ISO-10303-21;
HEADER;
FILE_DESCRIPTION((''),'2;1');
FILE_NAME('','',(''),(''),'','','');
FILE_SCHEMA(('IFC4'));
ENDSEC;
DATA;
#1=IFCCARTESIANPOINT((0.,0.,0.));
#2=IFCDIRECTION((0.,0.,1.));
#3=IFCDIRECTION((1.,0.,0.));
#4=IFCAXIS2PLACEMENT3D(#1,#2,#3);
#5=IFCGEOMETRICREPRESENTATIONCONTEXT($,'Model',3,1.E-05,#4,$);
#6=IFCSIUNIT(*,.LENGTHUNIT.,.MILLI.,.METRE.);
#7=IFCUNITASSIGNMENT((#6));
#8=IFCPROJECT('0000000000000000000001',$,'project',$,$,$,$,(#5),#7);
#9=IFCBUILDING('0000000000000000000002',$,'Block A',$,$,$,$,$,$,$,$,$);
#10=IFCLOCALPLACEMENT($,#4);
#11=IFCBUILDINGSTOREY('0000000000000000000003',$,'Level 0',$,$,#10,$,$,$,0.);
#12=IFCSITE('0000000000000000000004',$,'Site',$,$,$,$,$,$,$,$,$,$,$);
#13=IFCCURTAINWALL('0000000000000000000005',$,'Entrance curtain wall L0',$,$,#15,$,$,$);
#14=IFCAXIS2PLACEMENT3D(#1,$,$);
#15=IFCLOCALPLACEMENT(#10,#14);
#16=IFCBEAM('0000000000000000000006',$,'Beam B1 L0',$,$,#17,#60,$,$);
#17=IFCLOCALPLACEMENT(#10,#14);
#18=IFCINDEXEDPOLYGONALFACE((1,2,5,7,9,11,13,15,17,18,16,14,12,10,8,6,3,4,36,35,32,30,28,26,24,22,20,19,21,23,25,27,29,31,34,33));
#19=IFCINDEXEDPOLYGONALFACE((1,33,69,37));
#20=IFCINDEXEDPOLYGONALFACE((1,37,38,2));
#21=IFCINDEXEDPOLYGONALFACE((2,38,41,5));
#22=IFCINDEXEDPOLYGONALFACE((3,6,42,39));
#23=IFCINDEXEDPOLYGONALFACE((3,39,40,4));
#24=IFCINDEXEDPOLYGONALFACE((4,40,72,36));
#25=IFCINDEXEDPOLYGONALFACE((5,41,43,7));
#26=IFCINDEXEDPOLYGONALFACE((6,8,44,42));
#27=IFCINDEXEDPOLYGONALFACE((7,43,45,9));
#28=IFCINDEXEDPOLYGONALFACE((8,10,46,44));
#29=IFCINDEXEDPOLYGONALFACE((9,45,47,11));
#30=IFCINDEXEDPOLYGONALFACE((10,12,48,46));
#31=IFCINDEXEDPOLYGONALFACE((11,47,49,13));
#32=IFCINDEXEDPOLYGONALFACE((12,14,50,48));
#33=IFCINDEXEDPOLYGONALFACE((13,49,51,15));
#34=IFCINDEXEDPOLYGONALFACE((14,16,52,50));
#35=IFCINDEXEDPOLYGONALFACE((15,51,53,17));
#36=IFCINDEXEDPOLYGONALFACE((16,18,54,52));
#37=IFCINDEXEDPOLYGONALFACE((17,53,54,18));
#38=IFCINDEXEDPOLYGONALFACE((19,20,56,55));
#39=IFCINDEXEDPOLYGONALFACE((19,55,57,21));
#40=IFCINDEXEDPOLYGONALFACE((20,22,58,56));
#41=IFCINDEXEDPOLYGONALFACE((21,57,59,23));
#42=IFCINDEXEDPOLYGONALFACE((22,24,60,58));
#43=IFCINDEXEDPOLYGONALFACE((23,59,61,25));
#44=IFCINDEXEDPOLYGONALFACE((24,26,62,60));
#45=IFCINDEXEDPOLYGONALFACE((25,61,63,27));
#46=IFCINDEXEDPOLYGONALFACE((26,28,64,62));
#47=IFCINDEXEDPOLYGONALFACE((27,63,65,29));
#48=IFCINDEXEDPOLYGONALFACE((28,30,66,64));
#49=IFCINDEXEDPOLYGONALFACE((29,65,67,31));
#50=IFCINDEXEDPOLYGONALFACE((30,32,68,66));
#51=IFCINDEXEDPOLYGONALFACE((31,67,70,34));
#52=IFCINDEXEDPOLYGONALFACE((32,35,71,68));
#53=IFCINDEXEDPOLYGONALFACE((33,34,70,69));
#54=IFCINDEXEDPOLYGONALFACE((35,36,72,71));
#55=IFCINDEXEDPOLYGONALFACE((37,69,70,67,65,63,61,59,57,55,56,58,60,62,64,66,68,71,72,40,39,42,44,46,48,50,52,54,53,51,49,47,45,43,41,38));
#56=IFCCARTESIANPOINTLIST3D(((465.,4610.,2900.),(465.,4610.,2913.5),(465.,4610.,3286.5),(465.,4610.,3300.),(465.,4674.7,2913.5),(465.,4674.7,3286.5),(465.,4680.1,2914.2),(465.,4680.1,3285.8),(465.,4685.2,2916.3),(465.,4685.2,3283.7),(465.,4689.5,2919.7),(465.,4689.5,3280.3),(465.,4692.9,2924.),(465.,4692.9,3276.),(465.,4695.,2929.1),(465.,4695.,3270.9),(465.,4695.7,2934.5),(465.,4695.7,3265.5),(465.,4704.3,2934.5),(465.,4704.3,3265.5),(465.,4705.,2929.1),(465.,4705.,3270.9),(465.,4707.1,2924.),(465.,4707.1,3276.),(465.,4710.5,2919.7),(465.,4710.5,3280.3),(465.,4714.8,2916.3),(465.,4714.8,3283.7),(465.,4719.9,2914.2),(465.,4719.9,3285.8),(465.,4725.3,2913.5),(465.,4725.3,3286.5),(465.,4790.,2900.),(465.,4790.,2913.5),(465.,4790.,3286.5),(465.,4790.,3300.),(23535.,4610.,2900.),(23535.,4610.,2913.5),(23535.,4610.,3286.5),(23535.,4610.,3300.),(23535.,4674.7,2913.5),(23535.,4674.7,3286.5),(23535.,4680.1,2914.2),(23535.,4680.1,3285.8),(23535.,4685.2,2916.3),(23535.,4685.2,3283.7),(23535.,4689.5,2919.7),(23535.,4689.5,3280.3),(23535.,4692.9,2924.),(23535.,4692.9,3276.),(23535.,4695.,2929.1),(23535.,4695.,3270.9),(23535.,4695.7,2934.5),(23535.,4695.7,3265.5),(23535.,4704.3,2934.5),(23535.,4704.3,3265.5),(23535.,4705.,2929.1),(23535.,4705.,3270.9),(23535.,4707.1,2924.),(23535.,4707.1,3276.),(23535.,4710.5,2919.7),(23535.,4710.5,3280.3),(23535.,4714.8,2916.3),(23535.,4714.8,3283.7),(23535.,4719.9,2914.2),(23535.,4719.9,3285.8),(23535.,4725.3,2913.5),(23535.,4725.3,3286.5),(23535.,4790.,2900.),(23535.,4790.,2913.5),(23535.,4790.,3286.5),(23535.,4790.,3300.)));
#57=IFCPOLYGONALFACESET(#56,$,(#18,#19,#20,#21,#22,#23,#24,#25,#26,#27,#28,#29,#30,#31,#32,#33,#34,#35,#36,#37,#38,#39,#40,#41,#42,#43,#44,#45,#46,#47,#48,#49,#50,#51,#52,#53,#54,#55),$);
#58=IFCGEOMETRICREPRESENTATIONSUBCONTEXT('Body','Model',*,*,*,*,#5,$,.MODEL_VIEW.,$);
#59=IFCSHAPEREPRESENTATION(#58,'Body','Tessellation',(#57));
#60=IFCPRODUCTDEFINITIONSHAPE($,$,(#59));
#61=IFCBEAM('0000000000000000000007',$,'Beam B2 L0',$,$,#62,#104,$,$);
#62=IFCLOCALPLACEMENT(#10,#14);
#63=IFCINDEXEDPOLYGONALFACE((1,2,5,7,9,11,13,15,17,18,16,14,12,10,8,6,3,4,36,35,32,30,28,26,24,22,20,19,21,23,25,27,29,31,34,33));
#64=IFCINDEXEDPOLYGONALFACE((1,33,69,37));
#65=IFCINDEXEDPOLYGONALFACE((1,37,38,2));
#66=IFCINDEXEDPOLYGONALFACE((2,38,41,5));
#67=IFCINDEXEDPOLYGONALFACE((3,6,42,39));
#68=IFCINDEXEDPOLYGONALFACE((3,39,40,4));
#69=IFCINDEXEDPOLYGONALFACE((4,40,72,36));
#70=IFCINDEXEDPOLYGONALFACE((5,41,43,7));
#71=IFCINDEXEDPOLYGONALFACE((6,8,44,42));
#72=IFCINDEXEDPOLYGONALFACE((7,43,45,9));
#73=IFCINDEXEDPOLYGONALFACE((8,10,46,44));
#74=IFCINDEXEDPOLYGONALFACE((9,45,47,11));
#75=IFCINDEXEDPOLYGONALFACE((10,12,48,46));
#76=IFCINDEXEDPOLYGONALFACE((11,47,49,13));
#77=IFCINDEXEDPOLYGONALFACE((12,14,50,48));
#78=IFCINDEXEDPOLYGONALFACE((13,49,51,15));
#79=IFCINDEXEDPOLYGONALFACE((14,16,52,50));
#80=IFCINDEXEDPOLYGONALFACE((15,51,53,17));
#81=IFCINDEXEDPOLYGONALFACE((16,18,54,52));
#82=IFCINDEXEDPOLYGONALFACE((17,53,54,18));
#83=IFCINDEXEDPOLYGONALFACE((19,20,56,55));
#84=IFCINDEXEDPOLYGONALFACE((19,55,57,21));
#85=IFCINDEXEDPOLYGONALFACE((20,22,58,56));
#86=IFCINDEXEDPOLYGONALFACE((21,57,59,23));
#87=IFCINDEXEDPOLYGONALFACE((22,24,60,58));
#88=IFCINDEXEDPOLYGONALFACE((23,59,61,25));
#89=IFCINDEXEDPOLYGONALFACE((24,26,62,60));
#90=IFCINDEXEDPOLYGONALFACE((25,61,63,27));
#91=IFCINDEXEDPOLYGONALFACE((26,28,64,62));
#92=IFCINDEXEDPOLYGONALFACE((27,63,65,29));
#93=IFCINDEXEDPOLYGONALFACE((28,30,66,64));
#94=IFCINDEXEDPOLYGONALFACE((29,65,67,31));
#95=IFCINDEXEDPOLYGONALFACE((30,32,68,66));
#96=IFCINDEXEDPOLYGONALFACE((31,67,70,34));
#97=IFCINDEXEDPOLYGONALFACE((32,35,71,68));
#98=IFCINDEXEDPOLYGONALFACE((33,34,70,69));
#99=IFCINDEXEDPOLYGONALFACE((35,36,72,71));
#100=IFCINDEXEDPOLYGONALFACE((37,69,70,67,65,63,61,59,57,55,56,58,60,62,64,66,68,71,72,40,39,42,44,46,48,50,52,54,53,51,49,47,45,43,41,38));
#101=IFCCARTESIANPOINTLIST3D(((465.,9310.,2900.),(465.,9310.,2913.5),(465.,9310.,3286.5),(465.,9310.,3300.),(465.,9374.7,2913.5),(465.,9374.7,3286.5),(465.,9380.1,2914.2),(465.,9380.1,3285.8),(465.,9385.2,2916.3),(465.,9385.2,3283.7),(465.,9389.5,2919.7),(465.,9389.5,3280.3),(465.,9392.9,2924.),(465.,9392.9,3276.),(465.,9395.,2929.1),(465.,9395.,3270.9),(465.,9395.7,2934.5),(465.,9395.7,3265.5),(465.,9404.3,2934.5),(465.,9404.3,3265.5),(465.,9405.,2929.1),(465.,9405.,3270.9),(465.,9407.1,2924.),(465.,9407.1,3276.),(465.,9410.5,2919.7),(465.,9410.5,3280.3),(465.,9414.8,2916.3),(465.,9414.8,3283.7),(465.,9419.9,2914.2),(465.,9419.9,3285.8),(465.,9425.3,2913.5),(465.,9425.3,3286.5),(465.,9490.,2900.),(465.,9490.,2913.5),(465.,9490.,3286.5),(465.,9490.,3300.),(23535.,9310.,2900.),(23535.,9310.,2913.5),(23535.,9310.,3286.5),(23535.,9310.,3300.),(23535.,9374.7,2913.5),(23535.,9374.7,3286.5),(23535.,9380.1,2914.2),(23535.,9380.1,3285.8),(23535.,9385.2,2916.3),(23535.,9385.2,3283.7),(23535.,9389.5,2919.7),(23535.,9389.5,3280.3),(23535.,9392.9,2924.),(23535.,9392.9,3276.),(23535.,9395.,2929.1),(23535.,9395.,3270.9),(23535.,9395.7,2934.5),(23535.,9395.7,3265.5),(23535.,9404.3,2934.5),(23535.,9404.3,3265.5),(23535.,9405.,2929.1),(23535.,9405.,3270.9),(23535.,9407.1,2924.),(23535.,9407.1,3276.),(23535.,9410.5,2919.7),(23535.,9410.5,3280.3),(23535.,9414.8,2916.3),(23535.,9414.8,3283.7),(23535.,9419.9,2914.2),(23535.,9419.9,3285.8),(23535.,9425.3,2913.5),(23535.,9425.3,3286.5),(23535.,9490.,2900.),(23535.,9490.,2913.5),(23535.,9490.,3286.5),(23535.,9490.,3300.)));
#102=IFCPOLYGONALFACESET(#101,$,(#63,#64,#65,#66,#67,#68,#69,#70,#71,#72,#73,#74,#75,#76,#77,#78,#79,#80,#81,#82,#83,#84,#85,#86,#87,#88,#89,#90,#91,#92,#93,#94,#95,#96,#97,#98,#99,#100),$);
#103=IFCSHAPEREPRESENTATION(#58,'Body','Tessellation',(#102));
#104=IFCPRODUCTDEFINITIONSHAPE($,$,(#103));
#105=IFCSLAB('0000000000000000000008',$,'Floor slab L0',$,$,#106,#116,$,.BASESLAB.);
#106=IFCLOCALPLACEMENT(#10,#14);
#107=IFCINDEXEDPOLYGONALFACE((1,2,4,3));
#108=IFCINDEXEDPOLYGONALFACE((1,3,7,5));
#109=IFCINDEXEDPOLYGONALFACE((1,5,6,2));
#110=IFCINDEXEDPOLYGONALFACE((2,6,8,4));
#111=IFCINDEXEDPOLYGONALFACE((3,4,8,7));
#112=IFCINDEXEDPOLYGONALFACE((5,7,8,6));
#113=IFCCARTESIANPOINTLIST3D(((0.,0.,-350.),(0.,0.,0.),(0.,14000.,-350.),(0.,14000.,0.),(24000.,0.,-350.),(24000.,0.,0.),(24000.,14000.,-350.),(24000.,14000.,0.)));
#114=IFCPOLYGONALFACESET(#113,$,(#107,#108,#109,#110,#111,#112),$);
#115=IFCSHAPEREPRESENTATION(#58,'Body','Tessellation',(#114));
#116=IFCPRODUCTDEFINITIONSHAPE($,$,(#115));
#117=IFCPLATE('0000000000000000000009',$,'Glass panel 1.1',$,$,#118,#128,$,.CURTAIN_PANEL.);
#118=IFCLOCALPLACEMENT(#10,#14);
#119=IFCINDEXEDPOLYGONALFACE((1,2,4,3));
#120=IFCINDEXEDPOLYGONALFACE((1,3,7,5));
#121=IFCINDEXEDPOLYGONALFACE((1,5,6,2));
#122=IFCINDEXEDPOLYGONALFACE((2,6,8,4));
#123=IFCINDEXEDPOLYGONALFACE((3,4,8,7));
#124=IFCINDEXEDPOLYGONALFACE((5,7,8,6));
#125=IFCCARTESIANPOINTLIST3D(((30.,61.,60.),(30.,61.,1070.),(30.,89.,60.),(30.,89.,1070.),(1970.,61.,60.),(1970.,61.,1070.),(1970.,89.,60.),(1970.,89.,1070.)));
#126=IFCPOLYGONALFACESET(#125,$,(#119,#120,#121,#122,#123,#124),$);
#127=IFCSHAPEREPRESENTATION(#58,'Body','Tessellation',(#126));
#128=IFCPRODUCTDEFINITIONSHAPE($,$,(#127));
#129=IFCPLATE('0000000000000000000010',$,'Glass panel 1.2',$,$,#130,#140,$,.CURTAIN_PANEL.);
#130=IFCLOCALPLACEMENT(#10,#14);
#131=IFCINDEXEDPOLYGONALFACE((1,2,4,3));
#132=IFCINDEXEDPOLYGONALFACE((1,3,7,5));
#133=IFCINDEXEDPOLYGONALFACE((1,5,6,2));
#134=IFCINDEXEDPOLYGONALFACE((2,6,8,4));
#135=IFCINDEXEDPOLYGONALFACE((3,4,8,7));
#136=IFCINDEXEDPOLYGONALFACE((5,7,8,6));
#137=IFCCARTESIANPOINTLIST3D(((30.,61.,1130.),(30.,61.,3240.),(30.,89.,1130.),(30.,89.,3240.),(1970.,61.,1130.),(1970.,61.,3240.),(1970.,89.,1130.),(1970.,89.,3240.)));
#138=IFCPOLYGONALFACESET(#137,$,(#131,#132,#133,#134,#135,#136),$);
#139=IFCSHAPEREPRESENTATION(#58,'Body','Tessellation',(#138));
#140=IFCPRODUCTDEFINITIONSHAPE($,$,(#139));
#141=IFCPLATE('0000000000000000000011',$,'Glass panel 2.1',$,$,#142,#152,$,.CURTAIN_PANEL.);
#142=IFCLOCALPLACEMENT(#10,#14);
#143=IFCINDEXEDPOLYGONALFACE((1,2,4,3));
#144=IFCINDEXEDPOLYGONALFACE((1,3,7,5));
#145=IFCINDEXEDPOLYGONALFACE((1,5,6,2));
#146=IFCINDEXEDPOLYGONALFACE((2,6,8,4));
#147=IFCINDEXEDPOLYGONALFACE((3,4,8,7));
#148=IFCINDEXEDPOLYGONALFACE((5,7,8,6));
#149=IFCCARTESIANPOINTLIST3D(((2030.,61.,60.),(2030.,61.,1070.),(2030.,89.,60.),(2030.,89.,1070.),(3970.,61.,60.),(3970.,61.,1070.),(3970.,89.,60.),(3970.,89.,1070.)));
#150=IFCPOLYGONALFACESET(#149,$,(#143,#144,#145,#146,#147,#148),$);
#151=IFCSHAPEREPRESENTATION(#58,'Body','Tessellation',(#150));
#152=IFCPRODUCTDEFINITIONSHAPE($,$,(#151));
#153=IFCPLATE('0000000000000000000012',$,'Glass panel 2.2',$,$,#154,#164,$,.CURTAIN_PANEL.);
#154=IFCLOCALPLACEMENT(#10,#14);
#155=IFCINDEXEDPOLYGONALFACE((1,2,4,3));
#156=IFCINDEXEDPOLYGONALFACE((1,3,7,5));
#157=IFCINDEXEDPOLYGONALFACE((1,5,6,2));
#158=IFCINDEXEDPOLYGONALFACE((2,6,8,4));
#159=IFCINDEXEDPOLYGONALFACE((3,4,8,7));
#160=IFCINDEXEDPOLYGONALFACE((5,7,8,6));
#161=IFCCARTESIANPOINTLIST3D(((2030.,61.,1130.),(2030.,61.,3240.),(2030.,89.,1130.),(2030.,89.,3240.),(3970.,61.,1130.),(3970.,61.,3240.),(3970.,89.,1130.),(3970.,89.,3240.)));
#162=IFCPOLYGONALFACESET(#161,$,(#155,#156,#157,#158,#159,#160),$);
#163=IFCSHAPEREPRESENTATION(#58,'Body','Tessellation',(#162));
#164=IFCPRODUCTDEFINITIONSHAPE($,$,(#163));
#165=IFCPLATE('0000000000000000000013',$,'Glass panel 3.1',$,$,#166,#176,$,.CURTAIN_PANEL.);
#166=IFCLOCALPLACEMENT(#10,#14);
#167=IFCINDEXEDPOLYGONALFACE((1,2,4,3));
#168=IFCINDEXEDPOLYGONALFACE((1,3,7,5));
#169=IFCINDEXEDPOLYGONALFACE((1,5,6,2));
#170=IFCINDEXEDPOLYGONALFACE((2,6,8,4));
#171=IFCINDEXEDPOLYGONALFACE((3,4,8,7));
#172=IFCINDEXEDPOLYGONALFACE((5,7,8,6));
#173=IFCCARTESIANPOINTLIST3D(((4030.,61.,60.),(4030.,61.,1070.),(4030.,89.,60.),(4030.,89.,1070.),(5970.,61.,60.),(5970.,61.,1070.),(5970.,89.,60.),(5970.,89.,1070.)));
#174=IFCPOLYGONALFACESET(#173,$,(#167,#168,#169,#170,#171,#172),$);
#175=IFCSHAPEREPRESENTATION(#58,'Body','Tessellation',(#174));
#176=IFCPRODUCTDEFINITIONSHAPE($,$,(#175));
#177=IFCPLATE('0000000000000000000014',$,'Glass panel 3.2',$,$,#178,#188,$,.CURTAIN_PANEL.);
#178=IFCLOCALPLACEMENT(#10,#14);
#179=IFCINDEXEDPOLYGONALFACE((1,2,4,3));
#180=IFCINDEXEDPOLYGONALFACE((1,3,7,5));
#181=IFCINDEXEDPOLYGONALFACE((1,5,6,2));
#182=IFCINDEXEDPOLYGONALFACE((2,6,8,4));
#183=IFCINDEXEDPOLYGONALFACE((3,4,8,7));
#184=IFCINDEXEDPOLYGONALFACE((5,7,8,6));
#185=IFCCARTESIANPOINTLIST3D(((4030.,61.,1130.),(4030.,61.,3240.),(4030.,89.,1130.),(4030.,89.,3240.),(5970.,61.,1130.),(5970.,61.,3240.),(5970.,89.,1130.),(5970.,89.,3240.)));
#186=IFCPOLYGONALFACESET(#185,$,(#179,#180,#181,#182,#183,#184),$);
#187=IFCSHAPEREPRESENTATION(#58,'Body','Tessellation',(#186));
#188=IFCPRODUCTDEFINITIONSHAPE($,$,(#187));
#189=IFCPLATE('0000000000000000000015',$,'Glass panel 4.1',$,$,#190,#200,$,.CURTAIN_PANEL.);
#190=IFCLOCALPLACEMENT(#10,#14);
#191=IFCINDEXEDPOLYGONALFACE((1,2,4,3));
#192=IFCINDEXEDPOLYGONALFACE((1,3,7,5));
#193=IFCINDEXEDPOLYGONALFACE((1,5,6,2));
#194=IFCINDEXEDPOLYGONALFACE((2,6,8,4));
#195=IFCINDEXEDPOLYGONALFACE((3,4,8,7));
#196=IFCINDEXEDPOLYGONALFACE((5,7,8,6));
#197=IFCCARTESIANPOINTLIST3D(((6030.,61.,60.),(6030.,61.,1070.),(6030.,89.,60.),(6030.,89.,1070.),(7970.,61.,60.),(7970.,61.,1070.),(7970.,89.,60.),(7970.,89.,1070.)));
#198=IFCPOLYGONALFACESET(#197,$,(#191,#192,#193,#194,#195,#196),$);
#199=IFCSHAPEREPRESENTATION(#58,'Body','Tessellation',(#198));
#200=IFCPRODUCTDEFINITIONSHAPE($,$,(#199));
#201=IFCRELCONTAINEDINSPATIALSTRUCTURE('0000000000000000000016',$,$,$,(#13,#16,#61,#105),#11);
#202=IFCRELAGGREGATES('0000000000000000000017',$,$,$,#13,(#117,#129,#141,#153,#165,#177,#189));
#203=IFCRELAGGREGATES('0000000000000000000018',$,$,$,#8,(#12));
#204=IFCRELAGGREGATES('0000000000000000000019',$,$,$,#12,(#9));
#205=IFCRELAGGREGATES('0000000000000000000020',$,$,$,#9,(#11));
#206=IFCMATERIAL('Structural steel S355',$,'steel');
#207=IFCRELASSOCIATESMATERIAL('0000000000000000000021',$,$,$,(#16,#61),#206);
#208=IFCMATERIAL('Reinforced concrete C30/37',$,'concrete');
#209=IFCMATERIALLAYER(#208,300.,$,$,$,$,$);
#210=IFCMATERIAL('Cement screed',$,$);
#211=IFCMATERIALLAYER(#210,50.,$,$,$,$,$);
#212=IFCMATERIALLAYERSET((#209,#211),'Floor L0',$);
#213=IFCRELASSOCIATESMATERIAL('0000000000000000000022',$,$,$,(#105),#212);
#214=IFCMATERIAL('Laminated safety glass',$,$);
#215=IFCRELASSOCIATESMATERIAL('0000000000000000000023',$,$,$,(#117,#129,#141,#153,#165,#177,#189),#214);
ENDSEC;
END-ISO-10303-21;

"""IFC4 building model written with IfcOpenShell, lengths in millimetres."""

from ifc_helpers import new_model, si_unit, frame, origin_with_axes, place, context, subcontext, project, spatial, indexed_curve, i_section, outline, extrude, material, layer, layer_set, layer_usage, material_profile, profile_set, element, aggregate, save


model = new_model("IFC4")

# Units and contexts
model_context = context("Model", 3, precision=1e-05, world=origin_with_axes())
body_context = subcontext(model_context, "Body", "Model", "MODEL_VIEW")
ifc_project = project(units=[si_unit("LENGTHUNIT", "METRE", prefix="MILLI")], contexts=[model_context])

# Site, building, storey
site = spatial("IfcSite", under=ifc_project, Name="Site")
building = spatial("IfcBuilding", under=site, Name="Block A")
storey_placement = place(None, origin_with_axes())
storey = spatial("IfcBuildingStorey", under=building, at=storey_placement, Name="Level 0", Elevation=0.0)

# Shared definitions
ifc_material_1 = material(Name="Structural steel S355", Category="steel")

# Curtain wall
curtain_wall_placement = place(storey_placement, origin_with_axes())
curtain_wall = element("IfcCurtainWall", 1, at=curtain_wall_placement, inside=storey, Name="Entrance curtain wall L0")

# Beams
ifc_material_profile_1 = material_profile(ifc_material_1, i_section(OverallWidth=180.0, OverallDepth=400.0, WebThickness=8.6, FlangeThickness=13.5, FilletRadius=21.0))
ifc_profile_set_1 = profile_set([ifc_material_profile_1], Name="IPE 400")
for number, where, z_axis, x_axis, name in (
    (2, (465.0, 4700.0, 3100.0), (1.0, 0.0, 0.0), (0.0, 1.0, 0.0), "Beam B1 L0"),
    (3, (465.0, 9400.0, 3100.0), (1.0, 0.0, 0.0), (0.0, 1.0, 0.0), "Beam B2 L0"),
):
    element("IfcBeam", number, at=place(storey_placement, frame(where, z_axis=z_axis, x_axis=x_axis)), inside=storey, material=ifc_profile_set_1, Name=name, context=body_context, shape_type="SweptSolid", body=[
        extrude(i_section(OverallWidth=180.0, OverallDepth=400.0, WebThickness=8.6, FlangeThickness=13.5, FilletRadius=21.0), origin_with_axes(), (0.0, 0.0, 1.0), 23070.0),
    ])

# Slab
ifc_material_2 = material(Name="Reinforced concrete C30/37", Category="concrete")
ifc_layer_1 = layer(ifc_material_2, 300.0)
ifc_material_3 = material(Name="Cement screed")
ifc_layer_2 = layer(ifc_material_3, 50.0)
ifc_layer_set_1 = layer_set([ifc_layer_1, ifc_layer_2], Name="Floor L0")
ifc_layer_usage_1 = layer_usage(ifc_layer_set_1, "AXIS3", "POSITIVE", 0.0)
slab_placement = place(storey_placement, frame((0.0, 0.0, -350.0), z_axis=(0.0, 0.0, 1.0), x_axis=(1.0, 0.0, 0.0)))
element("IfcSlab", 4, at=slab_placement, inside=storey, material=ifc_layer_usage_1, Name="Floor slab L0", PredefinedType="BASESLAB", context=body_context, shape_type="SweptSolid", body=[
    extrude(outline(indexed_curve([(0.0, 0.0), (24000.0, 0.0), (24000.0, 14000.0), (0.0, 14000.0), (0.0, 0.0)])), None, (0.0, 0.0, 1.0), 350.0),
])

# Plates
ifc_material_4 = material(Name="Laminated safety glass")
plate_1_placement = place(curtain_wall_placement, frame((30.0, 61.0, 60.0), z_axis=(0.0, 0.0, 1.0), x_axis=(1.0, 0.0, 0.0)))
plate_1 = element("IfcPlate", 5, at=plate_1_placement, material=ifc_material_4, Name="Glass panel 1.1", PredefinedType="CURTAIN_PANEL", context=body_context, shape_type="SweptSolid", body=[
    extrude(outline(indexed_curve([(0.0, 0.0), (0.0, 28.0), (1940.0, 28.0), (1940.0, 0.0), (0.0, 0.0)], self_intersect=False)), origin_with_axes(), (0.0, 0.0, 1.0), 1010.0),
])
plate_2_placement = place(curtain_wall_placement, frame((30.0, 61.0, 1130.0), z_axis=(0.0, 0.0, 1.0), x_axis=(1.0, 0.0, 0.0)))
plate_2 = element("IfcPlate", 6, at=plate_2_placement, material=ifc_material_4, Name="Glass panel 1.2", PredefinedType="CURTAIN_PANEL", context=body_context, shape_type="SweptSolid", body=[
    extrude(outline(indexed_curve([(0.0, 0.0), (0.0, 28.0), (1940.0, 28.0), (1940.0, 0.0), (0.0, 0.0)], self_intersect=False)), origin_with_axes(), (0.0, 0.0, 1.0), 2110.0),
])
plate_3_placement = place(curtain_wall_placement, frame((2030.0, 61.0, 60.0), z_axis=(0.0, 0.0, 1.0), x_axis=(1.0, 0.0, 0.0)))
plate_3 = element("IfcPlate", 7, at=plate_3_placement, material=ifc_material_4, Name="Glass panel 2.1", PredefinedType="CURTAIN_PANEL", context=body_context, shape_type="SweptSolid", body=[
    extrude(outline(indexed_curve([(0.0, 0.0), (0.0, 28.0), (1940.0, 28.0), (1940.0, 0.0), (0.0, 0.0)], self_intersect=False)), origin_with_axes(), (0.0, 0.0, 1.0), 1010.0),
])
plate_4_placement = place(curtain_wall_placement, frame((2030.0, 61.0, 1130.0), z_axis=(0.0, 0.0, 1.0), x_axis=(1.0, 0.0, 0.0)))
plate_4 = element("IfcPlate", 8, at=plate_4_placement, material=ifc_material_4, Name="Glass panel 2.2", PredefinedType="CURTAIN_PANEL", context=body_context, shape_type="SweptSolid", body=[
    extrude(outline(indexed_curve([(0.0, 0.0), (0.0, 28.0), (1940.0, 28.0), (1940.0, 0.0), (0.0, 0.0)], self_intersect=False)), origin_with_axes(), (0.0, 0.0, 1.0), 2110.0),
])
plate_5_placement = place(curtain_wall_placement, frame((4030.0, 61.0, 60.0), z_axis=(0.0, 0.0, 1.0), x_axis=(1.0, 0.0, 0.0)))
plate_5 = element("IfcPlate", 9, at=plate_5_placement, material=ifc_material_4, Name="Glass panel 3.1", PredefinedType="CURTAIN_PANEL", context=body_context, shape_type="SweptSolid", body=[
    extrude(outline(indexed_curve([(0.0, 0.0), (0.0, 28.0), (1940.0, 28.0), (1940.0, 0.0), (0.0, 0.0)], self_intersect=False)), origin_with_axes(), (0.0, 0.0, 1.0), 1010.0),
])
plate_6_placement = place(curtain_wall_placement, frame((4030.0, 61.0, 1130.0), z_axis=(0.0, 0.0, 1.0), x_axis=(1.0, 0.0, 0.0)))
plate_6 = element("IfcPlate", 10, at=plate_6_placement, material=ifc_material_4, Name="Glass panel 3.2", PredefinedType="CURTAIN_PANEL", context=body_context, shape_type="SweptSolid", body=[
    extrude(outline(indexed_curve([(0.0, 0.0), (0.0, 28.0), (1940.0, 28.0), (1940.0, 0.0), (0.0, 0.0)], self_intersect=False)), origin_with_axes(), (0.0, 0.0, 1.0), 2110.0),
])
plate_7_placement = place(curtain_wall_placement, frame((6030.0, 61.0, 60.0), z_axis=(0.0, 0.0, 1.0), x_axis=(1.0, 0.0, 0.0)))
plate_7 = element("IfcPlate", 11, at=plate_7_placement, material=ifc_material_4, Name="Glass panel 4.1", PredefinedType="CURTAIN_PANEL", context=body_context, shape_type="SweptSolid", body=[
    extrude(outline(indexed_curve([(0.0, 0.0), (0.0, 28.0), (1940.0, 28.0), (1940.0, 0.0), (0.0, 0.0)], self_intersect=False)), origin_with_axes(), (0.0, 0.0, 1.0), 1010.0),
])
aggregate(curtain_wall, [plate_1, plate_2, plate_3, plate_4, plate_5, plate_6, plate_7])

save(model, "model.ifc")
